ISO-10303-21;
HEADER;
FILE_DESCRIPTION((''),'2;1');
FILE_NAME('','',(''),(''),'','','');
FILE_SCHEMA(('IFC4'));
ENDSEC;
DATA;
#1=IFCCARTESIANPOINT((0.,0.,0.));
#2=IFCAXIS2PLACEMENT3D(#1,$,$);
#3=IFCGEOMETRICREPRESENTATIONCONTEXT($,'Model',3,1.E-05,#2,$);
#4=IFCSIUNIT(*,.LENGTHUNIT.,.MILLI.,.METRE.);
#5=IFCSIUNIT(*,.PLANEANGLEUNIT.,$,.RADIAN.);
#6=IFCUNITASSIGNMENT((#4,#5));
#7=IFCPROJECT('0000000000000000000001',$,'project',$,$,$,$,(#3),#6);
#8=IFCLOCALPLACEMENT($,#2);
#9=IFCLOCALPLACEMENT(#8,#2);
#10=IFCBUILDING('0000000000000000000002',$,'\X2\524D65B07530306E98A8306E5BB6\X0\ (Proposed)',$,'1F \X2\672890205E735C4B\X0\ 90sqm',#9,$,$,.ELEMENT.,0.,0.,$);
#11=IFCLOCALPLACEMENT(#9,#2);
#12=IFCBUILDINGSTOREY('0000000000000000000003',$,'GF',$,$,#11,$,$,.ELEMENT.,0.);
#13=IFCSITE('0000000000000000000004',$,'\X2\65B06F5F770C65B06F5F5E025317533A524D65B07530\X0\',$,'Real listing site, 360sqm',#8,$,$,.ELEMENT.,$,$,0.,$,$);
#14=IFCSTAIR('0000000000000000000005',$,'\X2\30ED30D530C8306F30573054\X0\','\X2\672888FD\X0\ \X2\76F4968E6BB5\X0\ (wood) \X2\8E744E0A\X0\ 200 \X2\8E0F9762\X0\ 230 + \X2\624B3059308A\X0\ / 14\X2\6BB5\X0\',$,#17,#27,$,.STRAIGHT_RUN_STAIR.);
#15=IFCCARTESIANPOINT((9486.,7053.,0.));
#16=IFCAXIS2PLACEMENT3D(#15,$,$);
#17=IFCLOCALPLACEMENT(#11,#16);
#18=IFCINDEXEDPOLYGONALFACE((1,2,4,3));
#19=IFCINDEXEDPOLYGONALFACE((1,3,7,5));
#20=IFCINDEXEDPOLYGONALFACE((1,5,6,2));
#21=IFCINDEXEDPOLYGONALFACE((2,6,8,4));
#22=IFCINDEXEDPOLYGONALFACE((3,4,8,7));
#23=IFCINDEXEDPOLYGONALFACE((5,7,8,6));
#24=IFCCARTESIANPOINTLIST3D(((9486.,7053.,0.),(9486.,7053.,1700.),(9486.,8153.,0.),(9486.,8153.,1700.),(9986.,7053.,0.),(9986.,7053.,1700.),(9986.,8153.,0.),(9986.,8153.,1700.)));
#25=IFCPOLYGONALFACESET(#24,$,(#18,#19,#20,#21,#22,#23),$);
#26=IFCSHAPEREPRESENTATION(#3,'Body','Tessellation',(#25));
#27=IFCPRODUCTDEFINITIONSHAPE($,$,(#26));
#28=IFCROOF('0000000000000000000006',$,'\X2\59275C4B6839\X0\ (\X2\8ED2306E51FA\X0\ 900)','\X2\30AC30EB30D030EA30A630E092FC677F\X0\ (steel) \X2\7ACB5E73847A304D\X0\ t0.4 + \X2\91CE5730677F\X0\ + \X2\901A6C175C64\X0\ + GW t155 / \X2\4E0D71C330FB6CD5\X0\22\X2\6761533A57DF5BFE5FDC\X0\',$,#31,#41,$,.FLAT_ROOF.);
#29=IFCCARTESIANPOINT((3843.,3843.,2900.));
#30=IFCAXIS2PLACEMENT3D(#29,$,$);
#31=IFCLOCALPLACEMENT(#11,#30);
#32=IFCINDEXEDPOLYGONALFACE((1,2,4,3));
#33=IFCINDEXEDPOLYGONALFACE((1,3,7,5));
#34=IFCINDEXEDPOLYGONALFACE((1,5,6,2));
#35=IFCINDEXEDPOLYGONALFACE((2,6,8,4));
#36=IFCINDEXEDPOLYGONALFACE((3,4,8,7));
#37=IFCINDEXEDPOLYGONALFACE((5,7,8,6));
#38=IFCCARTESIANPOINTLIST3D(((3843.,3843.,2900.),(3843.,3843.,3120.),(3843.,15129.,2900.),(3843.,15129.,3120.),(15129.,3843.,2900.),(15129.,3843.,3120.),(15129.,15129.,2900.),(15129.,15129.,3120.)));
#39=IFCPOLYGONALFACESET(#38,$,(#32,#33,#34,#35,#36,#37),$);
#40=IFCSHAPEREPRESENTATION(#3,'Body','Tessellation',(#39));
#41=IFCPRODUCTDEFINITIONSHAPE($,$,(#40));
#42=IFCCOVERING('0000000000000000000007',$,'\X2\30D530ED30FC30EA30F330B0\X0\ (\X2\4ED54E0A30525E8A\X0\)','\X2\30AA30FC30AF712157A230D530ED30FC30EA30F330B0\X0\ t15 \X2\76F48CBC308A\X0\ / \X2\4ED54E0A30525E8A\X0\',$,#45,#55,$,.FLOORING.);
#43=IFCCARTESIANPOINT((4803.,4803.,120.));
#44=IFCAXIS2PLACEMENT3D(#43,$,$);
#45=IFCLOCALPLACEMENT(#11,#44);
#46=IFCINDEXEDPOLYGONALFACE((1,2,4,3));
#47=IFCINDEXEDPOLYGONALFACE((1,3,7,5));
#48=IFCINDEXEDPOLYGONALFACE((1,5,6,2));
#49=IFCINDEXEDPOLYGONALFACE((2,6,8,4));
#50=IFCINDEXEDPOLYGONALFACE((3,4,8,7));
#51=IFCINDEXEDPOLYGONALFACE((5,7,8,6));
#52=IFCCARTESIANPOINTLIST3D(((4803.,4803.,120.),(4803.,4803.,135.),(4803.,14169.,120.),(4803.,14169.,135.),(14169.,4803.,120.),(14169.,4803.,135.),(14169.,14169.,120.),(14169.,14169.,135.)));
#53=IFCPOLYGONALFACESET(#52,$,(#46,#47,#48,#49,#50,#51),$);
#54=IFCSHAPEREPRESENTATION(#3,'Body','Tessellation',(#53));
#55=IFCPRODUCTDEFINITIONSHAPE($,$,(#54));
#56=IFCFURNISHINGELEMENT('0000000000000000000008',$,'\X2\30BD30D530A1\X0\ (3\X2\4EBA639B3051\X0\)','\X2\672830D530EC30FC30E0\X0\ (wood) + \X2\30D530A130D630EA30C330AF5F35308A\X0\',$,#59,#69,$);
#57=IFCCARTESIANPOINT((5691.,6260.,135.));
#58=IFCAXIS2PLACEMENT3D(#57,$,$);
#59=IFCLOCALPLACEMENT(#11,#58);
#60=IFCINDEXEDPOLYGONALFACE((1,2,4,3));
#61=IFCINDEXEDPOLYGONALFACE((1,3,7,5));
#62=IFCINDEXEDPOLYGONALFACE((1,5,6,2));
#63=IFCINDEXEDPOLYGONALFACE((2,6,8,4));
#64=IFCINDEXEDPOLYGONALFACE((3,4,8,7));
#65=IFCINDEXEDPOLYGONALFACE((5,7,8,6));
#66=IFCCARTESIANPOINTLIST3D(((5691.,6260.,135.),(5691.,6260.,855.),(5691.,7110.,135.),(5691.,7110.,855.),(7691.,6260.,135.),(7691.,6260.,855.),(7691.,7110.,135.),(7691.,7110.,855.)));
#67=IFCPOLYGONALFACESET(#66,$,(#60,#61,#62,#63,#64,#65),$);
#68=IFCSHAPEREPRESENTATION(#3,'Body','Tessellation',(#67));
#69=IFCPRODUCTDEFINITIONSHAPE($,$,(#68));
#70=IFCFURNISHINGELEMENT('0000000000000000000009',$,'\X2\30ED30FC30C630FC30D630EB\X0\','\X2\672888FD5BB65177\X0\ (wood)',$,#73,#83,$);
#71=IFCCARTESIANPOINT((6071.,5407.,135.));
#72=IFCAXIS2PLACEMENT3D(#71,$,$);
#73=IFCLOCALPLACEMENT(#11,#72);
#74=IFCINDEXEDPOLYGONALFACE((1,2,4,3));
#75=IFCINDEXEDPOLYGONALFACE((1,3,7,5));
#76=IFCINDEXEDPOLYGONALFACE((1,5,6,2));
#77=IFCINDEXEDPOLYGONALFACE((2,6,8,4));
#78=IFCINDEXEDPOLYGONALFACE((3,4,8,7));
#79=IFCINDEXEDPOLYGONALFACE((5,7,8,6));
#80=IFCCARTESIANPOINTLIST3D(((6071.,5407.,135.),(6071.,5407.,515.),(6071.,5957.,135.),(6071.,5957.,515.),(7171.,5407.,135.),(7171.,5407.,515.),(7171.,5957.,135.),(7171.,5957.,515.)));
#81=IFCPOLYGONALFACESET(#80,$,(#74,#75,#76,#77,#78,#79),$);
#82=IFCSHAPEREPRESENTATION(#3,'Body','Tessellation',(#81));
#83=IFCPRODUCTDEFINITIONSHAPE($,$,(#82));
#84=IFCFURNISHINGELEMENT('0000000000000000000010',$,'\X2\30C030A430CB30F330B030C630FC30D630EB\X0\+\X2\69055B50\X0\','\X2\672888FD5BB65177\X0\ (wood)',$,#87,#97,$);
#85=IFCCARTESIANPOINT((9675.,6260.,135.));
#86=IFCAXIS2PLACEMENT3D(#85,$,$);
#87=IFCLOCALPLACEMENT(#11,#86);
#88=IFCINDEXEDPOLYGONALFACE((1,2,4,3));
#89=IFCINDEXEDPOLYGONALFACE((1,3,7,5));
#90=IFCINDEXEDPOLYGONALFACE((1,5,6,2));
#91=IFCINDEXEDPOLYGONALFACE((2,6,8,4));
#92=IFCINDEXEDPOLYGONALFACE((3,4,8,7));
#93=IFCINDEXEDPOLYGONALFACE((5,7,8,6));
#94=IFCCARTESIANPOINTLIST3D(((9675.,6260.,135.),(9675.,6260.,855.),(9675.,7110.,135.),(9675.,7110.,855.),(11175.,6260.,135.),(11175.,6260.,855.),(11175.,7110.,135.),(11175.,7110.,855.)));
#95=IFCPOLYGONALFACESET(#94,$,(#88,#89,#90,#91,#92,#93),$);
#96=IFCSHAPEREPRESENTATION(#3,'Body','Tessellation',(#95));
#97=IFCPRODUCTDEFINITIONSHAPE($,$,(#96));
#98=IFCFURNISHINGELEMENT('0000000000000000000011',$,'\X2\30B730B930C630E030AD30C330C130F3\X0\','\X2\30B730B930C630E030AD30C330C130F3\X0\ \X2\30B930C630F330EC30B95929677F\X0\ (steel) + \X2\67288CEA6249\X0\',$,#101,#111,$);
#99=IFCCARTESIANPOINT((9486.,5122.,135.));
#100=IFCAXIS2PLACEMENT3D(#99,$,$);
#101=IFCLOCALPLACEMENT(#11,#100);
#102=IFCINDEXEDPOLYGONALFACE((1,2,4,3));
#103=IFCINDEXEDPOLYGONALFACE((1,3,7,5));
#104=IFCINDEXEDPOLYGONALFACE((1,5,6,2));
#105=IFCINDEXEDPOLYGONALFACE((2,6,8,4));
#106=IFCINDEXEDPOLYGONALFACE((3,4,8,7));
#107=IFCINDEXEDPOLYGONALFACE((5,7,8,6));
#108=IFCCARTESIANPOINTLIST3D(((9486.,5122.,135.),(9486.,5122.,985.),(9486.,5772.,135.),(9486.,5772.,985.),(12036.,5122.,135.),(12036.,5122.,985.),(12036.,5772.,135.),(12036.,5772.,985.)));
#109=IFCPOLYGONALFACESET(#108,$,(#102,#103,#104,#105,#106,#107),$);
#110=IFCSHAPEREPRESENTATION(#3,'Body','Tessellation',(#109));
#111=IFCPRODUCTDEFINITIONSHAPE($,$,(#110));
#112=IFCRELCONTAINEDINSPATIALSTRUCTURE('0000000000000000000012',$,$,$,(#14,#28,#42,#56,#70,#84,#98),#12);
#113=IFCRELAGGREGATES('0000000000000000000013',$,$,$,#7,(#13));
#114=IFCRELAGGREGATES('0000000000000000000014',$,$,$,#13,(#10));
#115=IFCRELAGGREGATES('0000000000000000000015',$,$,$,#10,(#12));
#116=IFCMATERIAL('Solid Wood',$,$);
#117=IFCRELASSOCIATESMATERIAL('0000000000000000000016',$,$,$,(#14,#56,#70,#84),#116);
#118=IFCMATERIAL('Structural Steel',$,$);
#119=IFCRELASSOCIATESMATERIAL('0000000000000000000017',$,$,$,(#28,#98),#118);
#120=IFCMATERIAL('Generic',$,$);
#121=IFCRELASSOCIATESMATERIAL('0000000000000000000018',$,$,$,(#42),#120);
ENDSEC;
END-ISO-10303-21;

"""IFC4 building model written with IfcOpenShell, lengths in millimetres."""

from ifc_helpers import new_model, si_unit, frame, frame_2d, origin, place, context, project, spatial, rectangle, extrude, material, element, save


model = new_model("IFC4")

# Units and contexts
model_context = context("Model", 3, precision=1e-05, world=origin())
ifc_project = project(units=[si_unit("LENGTHUNIT", "METRE", prefix="MILLI"), si_unit("PLANEANGLEUNIT", "RADIAN")], contexts=[model_context])

# Site, building, storey
site_placement = place(None, origin())
site = spatial("IfcSite", under=ifc_project, at=site_placement, Name="新潟県新潟市北区前新田", ObjectType="Real listing site, 360sqm", CompositionType="ELEMENT", RefElevation=0.0)
building_placement = place(site_placement, origin())
building = spatial("IfcBuilding", under=site, at=building_placement, Name="前新田の風の家 (Proposed)", ObjectType="1F 木造平屋 90sqm", CompositionType="ELEMENT", ElevationOfRefHeight=0.0, ElevationOfTerrain=0.0)
storey_placement = place(building_placement, origin())
storey = spatial("IfcBuildingStorey", under=building, at=storey_placement, Name="GF", CompositionType="ELEMENT", Elevation=0.0)

# Shared definitions
ifc_material_1 = material(Name="Solid Wood")

# Stair
stair_placement = place(storey_placement, frame((9486.0, 7053.0, 0.0)))
element("IfcStair", 1, at=stair_placement, inside=storey, material=ifc_material_1, Name="ロフトはしご", Description="木製 直階段 (wood) 蹴上 200 踏面 230 + 手すり / 14段", PredefinedType="STRAIGHT_RUN_STAIR", context=model_context, shape_type="SweptSolid", body=[
    extrude(rectangle(XDim=500.0, YDim=1100.0, at=frame_2d((250.0, 550.0))), frame((9486.0, 7053.0, 0.0)), (0.0, 0.0, 1.0), 1700.0),
])

# Roof
ifc_material_2 = material(Name="Structural Steel")
roof_placement = place(storey_placement, frame((3843.0, 3843.0, 2900.0)))
element("IfcRoof", 2, at=roof_placement, inside=storey, material=ifc_material_2, Name="大屋根 (軒の出 900)", Description="ガルバリウム鋼板 (steel) 立平葺き t0.4 + 野地板 + 通気層 + GW t155 / 不燃・法22条区域対応", PredefinedType="FLAT_ROOF", context=model_context, shape_type="SweptSolid", body=[
    extrude(rectangle(XDim=11286.0, YDim=11286.0, at=frame_2d((5643.0, 5643.0))), frame((3843.0, 3843.0, 2900.0)), (0.0, 0.0, 1.0), 220.0),
])

# Covering
ifc_material_3 = material(Name="Generic")
covering_placement = place(storey_placement, frame((4803.0, 4803.0, 120.0)))
element("IfcCovering", 3, at=covering_placement, inside=storey, material=ifc_material_3, Name="フローリング (仕上げ床)", Description="オーク無垢フローリング t15 直貼り / 仕上げ床", PredefinedType="FLOORING", context=model_context, shape_type="SweptSolid", body=[
    extrude(rectangle(XDim=9366.0, YDim=9366.0, at=frame_2d((4683.0, 4683.0))), frame((4803.0, 4803.0, 120.0)), (0.0, 0.0, 1.0), 15.0),
])

# Furnishing elements
furnishing_1_placement = place(storey_placement, frame((5691.0, 6260.0, 135.0)))
element("IfcFurnishingElement", 4, at=furnishing_1_placement, inside=storey, material=ifc_material_1, Name="ソファ (3人掛け)", Description="木フレーム (wood) + ファブリック張り", context=model_context, shape_type="SweptSolid", body=[
    extrude(rectangle(XDim=2000.0, YDim=850.0, at=frame_2d((1000.0, 425.0))), frame((5691.0, 6260.0, 135.0)), (0.0, 0.0, 1.0), 720.0),
])
furnishing_2_placement = place(storey_placement, frame((6071.0, 5407.0, 135.0)))
element("IfcFurnishingElement", 5, at=furnishing_2_placement, inside=storey, material=ifc_material_1, Name="ローテーブル", Description="木製家具 (wood)", context=model_context, shape_type="SweptSolid", body=[
    extrude(rectangle(XDim=1100.0, YDim=550.0, at=frame_2d((550.0, 275.0))), frame((6071.0, 5407.0, 135.0)), (0.0, 0.0, 1.0), 380.0),
])
furnishing_3_placement = place(storey_placement, frame((9675.0, 6260.0, 135.0)))
element("IfcFurnishingElement", 6, at=furnishing_3_placement, inside=storey, material=ifc_material_1, Name="ダイニングテーブル+椅子", Description="木製家具 (wood)", context=model_context, shape_type="SweptSolid", body=[
    extrude(rectangle(XDim=1500.0, YDim=850.0, at=frame_2d((750.0, 425.0))), frame((9675.0, 6260.0, 135.0)), (0.0, 0.0, 1.0), 720.0),
])
furnishing_4_placement = place(storey_placement, frame((9486.0, 5122.0, 135.0)))
element("IfcFurnishingElement", 7, at=furnishing_4_placement, inside=storey, material=ifc_material_2, Name="システムキッチン", Description="システムキッチン ステンレス天板 (steel) + 木質扉", context=model_context, shape_type="SweptSolid", body=[
    extrude(rectangle(XDim=2550.0, YDim=650.0, at=frame_2d((1275.0, 325.0))), frame((9486.0, 5122.0, 135.0)), (0.0, 0.0, 1.0), 850.0),
])

save(model, "model.ifc")
